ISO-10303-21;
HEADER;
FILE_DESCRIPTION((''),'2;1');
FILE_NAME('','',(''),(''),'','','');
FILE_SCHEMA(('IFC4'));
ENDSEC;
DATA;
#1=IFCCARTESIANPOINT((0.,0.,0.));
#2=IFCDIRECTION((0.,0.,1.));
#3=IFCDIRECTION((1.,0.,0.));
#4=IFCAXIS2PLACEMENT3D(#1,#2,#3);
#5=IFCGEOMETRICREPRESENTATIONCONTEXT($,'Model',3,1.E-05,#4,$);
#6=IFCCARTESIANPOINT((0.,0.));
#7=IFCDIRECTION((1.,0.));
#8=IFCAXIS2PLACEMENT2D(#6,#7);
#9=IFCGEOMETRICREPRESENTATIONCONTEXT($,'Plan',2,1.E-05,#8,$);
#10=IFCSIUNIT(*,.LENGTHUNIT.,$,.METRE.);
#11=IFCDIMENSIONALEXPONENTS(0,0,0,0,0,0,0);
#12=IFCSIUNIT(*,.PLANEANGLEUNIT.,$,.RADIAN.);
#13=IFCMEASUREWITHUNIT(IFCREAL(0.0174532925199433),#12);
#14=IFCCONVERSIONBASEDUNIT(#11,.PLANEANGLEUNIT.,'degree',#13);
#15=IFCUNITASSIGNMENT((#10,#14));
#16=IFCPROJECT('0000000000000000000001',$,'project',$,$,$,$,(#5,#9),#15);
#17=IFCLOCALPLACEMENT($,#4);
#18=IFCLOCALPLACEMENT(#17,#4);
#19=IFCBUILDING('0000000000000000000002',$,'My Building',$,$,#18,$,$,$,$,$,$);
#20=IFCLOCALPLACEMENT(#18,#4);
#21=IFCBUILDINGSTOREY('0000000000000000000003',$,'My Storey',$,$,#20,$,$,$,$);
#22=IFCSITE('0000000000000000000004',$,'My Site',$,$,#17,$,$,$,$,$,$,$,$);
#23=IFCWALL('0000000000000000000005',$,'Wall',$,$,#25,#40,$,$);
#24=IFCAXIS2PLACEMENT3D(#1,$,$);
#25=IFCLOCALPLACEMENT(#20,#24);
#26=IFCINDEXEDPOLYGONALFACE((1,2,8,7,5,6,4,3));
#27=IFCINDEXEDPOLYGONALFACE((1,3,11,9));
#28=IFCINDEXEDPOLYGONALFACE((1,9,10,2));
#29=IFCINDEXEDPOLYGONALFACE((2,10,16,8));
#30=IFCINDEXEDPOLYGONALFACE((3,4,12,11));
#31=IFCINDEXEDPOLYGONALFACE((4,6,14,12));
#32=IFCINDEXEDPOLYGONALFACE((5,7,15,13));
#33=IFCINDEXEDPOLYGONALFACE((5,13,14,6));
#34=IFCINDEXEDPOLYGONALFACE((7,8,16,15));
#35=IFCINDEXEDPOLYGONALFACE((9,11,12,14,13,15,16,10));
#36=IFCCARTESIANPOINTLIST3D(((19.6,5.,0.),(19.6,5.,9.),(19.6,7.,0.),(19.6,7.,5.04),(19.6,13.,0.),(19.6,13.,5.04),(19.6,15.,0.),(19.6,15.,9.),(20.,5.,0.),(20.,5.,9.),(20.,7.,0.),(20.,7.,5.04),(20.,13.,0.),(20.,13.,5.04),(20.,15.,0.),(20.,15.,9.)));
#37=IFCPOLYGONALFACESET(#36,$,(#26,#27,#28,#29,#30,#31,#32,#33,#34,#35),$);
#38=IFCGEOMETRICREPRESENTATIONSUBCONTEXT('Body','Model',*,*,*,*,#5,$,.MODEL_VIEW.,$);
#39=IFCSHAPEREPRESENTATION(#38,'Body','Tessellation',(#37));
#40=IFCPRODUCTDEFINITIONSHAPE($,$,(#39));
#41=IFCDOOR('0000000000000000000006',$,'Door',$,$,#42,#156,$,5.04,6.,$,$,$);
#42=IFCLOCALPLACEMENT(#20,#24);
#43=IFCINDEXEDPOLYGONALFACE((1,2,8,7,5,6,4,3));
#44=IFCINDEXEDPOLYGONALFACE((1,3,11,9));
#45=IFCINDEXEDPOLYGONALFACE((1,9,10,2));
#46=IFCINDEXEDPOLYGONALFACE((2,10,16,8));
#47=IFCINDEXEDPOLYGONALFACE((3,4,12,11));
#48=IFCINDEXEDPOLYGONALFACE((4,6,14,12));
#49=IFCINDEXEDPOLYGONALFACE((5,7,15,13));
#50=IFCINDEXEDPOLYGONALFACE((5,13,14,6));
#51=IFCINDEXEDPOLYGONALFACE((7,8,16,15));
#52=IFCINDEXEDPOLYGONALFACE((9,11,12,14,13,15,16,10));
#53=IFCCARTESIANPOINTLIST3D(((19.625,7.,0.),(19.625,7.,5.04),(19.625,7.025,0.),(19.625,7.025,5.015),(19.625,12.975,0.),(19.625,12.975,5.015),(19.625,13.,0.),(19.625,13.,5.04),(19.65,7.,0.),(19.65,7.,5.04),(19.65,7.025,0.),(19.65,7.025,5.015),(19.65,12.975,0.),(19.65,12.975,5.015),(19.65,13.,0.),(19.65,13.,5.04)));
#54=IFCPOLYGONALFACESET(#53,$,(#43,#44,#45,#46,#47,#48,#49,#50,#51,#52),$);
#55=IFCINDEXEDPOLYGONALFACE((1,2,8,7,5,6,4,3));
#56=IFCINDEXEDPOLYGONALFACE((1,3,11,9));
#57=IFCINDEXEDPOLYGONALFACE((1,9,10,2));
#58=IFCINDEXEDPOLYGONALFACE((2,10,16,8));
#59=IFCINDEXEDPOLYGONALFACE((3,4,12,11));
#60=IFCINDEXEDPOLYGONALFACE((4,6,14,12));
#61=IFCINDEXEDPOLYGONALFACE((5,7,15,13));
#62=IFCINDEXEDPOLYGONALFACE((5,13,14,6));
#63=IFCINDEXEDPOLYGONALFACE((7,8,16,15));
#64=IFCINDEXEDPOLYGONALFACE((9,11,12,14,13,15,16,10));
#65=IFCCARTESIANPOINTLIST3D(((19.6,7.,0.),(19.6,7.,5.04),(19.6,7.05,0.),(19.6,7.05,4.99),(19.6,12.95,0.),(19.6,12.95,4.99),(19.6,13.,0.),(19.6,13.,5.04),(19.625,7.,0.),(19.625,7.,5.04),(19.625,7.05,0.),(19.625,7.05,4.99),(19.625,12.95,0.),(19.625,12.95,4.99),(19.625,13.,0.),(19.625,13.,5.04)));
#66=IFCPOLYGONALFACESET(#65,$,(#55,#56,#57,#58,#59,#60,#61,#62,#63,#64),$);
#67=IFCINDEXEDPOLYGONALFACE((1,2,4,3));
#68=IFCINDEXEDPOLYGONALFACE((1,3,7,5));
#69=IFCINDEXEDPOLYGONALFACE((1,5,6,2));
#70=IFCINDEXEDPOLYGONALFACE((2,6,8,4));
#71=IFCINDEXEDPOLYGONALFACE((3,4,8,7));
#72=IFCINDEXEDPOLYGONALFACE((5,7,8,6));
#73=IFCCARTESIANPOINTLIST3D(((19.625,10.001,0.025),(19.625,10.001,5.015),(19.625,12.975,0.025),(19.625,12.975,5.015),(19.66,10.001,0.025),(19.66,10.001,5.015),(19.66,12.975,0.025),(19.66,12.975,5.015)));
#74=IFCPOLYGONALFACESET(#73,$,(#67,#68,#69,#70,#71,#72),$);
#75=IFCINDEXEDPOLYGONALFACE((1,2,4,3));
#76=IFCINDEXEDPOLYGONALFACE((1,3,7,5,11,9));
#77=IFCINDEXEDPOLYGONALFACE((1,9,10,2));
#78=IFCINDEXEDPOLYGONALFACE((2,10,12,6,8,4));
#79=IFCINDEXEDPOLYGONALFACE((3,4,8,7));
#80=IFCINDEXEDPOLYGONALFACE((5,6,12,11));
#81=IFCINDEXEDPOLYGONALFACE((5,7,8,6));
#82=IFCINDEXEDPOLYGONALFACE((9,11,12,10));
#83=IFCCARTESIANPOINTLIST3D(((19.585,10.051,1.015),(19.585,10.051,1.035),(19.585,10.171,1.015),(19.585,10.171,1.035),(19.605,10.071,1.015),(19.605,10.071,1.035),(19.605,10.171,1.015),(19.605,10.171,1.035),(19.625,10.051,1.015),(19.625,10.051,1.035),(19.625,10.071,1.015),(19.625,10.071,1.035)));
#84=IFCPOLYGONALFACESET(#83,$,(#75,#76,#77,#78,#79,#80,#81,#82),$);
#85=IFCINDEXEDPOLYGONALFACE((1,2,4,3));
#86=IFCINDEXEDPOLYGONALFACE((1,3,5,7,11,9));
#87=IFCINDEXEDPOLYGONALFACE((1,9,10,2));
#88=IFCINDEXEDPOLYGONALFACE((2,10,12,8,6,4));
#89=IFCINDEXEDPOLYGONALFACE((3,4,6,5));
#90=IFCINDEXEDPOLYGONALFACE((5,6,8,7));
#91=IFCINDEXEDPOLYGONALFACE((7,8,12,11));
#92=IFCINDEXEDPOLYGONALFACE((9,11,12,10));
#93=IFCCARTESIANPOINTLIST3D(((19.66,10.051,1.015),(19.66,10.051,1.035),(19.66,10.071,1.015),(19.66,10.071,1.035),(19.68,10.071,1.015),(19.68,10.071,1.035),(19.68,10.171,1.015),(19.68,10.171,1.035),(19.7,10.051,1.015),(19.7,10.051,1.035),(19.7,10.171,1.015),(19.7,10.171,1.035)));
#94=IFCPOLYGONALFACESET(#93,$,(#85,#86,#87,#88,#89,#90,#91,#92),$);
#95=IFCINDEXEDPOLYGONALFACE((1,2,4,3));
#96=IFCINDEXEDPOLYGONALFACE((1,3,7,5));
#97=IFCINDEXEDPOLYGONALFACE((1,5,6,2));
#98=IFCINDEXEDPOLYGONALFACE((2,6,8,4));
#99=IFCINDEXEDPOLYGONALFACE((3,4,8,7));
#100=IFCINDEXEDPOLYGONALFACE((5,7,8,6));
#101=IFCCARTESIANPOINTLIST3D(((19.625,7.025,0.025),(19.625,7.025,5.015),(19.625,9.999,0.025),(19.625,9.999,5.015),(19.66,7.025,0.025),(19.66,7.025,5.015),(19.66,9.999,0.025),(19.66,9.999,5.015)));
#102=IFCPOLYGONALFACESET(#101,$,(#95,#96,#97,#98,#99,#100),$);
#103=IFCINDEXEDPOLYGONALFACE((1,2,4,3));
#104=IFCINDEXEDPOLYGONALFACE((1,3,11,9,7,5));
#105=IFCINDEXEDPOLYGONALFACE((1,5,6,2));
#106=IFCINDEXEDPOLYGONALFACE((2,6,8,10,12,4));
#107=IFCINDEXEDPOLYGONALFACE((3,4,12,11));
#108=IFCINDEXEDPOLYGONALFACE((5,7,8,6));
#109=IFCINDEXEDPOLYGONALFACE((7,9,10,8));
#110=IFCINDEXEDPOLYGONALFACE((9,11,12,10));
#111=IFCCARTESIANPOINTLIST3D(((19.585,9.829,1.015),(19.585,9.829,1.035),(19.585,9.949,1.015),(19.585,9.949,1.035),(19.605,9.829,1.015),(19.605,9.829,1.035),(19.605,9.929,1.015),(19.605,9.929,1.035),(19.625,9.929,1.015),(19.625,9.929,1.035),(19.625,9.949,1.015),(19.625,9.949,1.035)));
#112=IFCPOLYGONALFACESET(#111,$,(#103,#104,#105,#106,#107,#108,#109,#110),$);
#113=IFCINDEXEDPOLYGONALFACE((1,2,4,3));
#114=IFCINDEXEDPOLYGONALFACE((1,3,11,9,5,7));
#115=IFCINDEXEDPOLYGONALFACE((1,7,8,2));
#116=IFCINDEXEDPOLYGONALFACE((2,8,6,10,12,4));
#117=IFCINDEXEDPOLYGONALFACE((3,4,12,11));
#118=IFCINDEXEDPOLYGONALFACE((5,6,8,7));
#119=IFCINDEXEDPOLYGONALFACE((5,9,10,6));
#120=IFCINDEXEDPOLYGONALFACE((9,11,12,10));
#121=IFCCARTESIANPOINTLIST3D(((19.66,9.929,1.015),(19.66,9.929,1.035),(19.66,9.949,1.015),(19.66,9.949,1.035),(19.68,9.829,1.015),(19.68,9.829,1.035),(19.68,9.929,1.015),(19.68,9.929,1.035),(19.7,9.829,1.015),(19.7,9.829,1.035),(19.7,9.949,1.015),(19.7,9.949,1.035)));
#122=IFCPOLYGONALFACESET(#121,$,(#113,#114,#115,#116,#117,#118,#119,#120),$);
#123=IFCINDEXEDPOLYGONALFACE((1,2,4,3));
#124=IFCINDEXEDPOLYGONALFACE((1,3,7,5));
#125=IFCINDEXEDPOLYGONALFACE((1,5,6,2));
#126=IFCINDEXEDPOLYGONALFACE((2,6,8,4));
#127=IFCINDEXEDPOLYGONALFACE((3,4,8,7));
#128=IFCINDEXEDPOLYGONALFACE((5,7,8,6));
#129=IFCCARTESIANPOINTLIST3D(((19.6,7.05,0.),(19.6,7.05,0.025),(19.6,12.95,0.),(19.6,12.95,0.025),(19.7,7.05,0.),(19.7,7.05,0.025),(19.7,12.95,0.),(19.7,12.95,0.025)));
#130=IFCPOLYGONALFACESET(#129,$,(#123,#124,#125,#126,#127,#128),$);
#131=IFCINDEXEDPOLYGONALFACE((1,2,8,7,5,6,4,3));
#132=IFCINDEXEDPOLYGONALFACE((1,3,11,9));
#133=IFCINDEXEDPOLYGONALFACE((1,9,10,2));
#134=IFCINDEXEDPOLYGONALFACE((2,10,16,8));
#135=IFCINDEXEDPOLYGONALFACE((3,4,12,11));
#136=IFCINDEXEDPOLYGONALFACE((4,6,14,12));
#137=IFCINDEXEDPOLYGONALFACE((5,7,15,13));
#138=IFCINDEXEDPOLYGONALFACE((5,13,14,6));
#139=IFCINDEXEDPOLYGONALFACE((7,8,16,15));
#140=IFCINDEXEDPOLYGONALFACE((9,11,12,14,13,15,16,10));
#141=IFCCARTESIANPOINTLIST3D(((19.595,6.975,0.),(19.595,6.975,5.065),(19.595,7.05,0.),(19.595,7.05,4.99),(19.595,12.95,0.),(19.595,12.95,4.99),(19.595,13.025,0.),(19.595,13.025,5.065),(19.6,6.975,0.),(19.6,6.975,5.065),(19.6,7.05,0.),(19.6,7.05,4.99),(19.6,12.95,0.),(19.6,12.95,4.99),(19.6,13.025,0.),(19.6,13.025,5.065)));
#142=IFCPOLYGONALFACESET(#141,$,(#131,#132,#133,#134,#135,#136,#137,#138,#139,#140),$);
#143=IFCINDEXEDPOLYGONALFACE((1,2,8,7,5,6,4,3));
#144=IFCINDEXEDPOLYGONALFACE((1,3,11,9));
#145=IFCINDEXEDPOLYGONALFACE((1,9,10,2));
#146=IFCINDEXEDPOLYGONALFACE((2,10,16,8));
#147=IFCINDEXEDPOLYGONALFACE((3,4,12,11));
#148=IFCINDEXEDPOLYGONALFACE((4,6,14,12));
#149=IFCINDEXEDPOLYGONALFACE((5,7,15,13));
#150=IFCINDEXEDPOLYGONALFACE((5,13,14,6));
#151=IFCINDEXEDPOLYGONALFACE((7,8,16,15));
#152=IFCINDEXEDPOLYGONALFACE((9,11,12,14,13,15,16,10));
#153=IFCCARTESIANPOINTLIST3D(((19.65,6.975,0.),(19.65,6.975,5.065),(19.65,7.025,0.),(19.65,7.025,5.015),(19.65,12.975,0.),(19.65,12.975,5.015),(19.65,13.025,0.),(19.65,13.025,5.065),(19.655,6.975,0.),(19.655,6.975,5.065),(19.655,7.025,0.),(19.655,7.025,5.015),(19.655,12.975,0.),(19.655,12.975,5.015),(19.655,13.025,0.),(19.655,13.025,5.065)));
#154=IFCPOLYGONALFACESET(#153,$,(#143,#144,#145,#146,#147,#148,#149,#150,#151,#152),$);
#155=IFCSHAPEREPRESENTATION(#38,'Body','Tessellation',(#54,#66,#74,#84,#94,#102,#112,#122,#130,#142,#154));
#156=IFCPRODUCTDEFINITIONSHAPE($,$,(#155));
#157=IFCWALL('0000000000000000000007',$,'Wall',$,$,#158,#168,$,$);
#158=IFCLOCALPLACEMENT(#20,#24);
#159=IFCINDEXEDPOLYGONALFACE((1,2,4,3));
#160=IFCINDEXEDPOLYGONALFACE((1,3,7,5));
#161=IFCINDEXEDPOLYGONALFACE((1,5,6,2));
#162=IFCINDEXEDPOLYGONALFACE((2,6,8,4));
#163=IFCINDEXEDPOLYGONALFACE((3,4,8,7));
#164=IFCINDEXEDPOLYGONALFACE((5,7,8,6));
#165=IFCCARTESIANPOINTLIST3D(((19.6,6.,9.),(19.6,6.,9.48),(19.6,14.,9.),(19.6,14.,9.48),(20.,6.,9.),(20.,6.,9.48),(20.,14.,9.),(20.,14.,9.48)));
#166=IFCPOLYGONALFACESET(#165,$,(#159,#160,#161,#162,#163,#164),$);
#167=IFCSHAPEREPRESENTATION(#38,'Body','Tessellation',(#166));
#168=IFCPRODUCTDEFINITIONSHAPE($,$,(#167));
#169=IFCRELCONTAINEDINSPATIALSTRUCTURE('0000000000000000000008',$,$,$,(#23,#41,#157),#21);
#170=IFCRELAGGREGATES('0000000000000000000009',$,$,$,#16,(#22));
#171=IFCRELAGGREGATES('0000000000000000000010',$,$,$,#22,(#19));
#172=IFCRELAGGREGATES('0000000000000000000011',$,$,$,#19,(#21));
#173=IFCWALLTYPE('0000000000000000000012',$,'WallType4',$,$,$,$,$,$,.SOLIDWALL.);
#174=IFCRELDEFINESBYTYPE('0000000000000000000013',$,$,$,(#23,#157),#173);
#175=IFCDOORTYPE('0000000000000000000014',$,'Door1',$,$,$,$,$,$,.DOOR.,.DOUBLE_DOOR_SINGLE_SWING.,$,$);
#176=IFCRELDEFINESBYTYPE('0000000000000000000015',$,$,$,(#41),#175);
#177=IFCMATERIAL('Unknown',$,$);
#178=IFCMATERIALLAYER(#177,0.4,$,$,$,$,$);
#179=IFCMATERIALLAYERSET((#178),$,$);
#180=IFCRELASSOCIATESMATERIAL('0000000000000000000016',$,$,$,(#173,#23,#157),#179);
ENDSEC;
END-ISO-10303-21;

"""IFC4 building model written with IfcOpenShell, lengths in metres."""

from ifc_helpers import new_model, entity, si_unit, converted_unit, frame, origin_with_axes, origin_2d_with_axis, place, context, subcontext, project, spatial, line, indexed_curve, outline, extrude, shape, source, transform, mapped, material, layer, layer_set, layer_usage, type_object, type_shapes, element, fill, save


model = new_model("IFC4")

# Units and contexts
model_context = context("Model", 3, precision=1e-05, world=origin_with_axes())
plan_context = context("Plan", 2, precision=1e-05, world=origin_2d_with_axis())
body_context_1 = subcontext(model_context, "Body", "Model", "MODEL_VIEW")
body_context_2 = subcontext(plan_context, "Body", "Plan", "PLAN_VIEW")
ifc_project = project(units=[si_unit("LENGTHUNIT", "METRE"), converted_unit("PLANEANGLEUNIT", "degree", entity("IfcReal", 0.0174532925199433), si_unit("PLANEANGLEUNIT", "RADIAN"), dimensions=[0, 0, 0, 0, 0, 0, 0])], contexts=[model_context, plan_context])

# Site, building, storey
site_placement = place(None, origin_with_axes())
site = spatial("IfcSite", under=ifc_project, at=site_placement, Name="My Site")
building_placement = place(site_placement, origin_with_axes())
building = spatial("IfcBuilding", under=site, at=building_placement, Name="My Building")
storey_placement = place(building_placement, origin_with_axes())
storey = spatial("IfcBuildingStorey", under=building, at=storey_placement, Name="My Storey")

# Shared definitions
ifc_material = material(Name="Unknown")
ifc_layer = layer(ifc_material, 0.4)
ifc_layer_set = layer_set([ifc_layer])
wall_type = type_object("IfcWallType", Name="WallType4", PredefinedType="SOLIDWALL", material=ifc_layer_set)

# Wall, opening, door
shared_shape_1 = source(origin_with_axes(), body_context_1, "Body", "SweptSolid", [
    extrude(outline(indexed_curve([(0.0, 0.0), (6.0, 0.0), (6.0, 5.04), (0.0, 5.04)], segments=[line(1, 2, 3, 4, 1)])), frame((0.0, -0.1, 0.0), z_axis=(0.0, -1.0, 0.0), x_axis=(1.0, 0.0, 0.0)), (0.0, 0.0, -1.0), 0.6),
])
door_type_1 = type_object("IfcDoorType", Name="Door1", OperationType="DOUBLE_DOOR_SINGLE_SWING", PredefinedType="DOOR")
shared_shape_2 = source(origin_with_axes(), body_context_1, "Body", "SweptSolid", [
    extrude(outline(indexed_curve([(0.0, 0.0), (0.0, 5.04), (6.0, 5.04), (6.0, 0.0), (5.975, 0.0), (5.975, 5.015), (0.025, 5.015), (0.025, 0.0)], segments=[line(1, 2, 3, 4, 5, 6, 7, 8, 1)])), frame((0.0, 0.025, 0.0), z_axis=(0.0, -1.0, 0.0), x_axis=(1.0, 0.0, 0.0)), (0.0, 0.0, -1.0), 0.025),
    extrude(outline(indexed_curve([(0.0, 0.0), (0.0, 5.04), (6.0, 5.04), (6.0, 0.0), (5.95, 0.0), (5.95, 4.99), (0.05, 4.99), (0.05, 0.0)], segments=[line(1, 2, 3, 4, 5, 6, 7, 8, 1)])), frame((0.0, 0.0, 0.0), z_axis=(0.0, -1.0, 0.0), x_axis=(1.0, 0.0, 0.0)), (0.0, 0.0, -1.0), 0.025),
    extrude(outline(indexed_curve([(0.0, 0.0), (2.974, 0.0), (2.974, 0.035), (0.0, 0.035)], segments=[line(1, 2, 3, 4, 1)])), frame((0.025, 0.025, 0.025), z_axis=(0.0, 0.0, 1.0), x_axis=(1.0, 0.0, 0.0)), (0.0, 0.0, 1.0), 4.99),
    extrude(outline(indexed_curve([(0.0, 0.0), (0.0, -0.04), (-0.12, -0.04), (-0.12, -0.02), (-0.02, -0.02), (-0.02, 0.0)], segments=[line(1, 2, 3, 4, 5, 6, 1)])), frame((2.949, 0.025, 1.015), z_axis=(0.0, 0.0, 1.0), x_axis=(1.0, 0.0, 0.0)), (0.0, 0.0, 1.0), 0.02),
    extrude(outline(indexed_curve([(0.0, 0.0), (0.0, 0.04), (-0.12, 0.04), (-0.12, 0.02), (-0.02, 0.02), (-0.02, 0.0)], segments=[line(1, 2, 3, 4, 5, 6, 1)])), frame((2.949, 0.06, 1.015), z_axis=(0.0, 0.0, 1.0), x_axis=(1.0, 0.0, 0.0)), (0.0, 0.0, 1.0), 0.02),
    extrude(outline(indexed_curve([(0.0, 0.0), (-2.974, 0.0), (-2.974, 0.035), (0.0, 0.035)], segments=[line(1, 2, 3, 4, 1)])), frame((5.975, 0.025, 0.025), z_axis=(0.0, 0.0, 1.0), x_axis=(1.0, 0.0, 0.0)), (0.0, 0.0, 1.0), 4.99),
    extrude(outline(indexed_curve([(0.0, 0.0), (0.0, -0.04), (0.12, -0.04), (0.12, -0.02), (0.02, -0.02), (0.02, 0.0)], segments=[line(1, 2, 3, 4, 5, 6, 1)])), frame((3.051, 0.025, 1.015), z_axis=(0.0, 0.0, 1.0), x_axis=(1.0, 0.0, 0.0)), (0.0, 0.0, 1.0), 0.02),
    extrude(outline(indexed_curve([(0.0, 0.0), (0.0, 0.04), (0.12, 0.04), (0.12, 0.02), (0.02, 0.02), (0.02, 0.0)], segments=[line(1, 2, 3, 4, 5, 6, 1)])), frame((3.051, 0.06, 1.015), z_axis=(0.0, 0.0, 1.0), x_axis=(1.0, 0.0, 0.0)), (0.0, 0.0, 1.0), 0.02),
    extrude(outline(indexed_curve([(0.0, 0.0), (5.9, 0.0), (5.9, 0.1), (0.0, 0.1)], segments=[line(1, 2, 3, 4, 1)])), frame((0.05, 0.0, 0.0), z_axis=(0.0, 0.0, 1.0), x_axis=(1.0, 0.0, 0.0)), (0.0, 0.0, 1.0), 0.025),
    extrude(outline(indexed_curve([(0.0, 0.0), (0.0, 5.065), (6.05, 5.065), (6.05, 0.0), (5.975, 0.0), (5.975, 4.99), (0.075, 4.99), (0.075, 0.0)], segments=[line(1, 2, 3, 4, 5, 6, 7, 8, 1)])), frame((-0.025, -0.005, 0.0), z_axis=(0.0, -1.0, 0.0), x_axis=(1.0, 0.0, 0.0)), (0.0, 0.0, -1.0), 0.005),
    extrude(outline(indexed_curve([(0.0, 0.0), (0.0, 5.065), (6.05, 5.065), (6.05, 0.0), (6.0, 0.0), (6.0, 5.015), (0.05, 5.015), (0.05, 0.0)], segments=[line(1, 2, 3, 4, 5, 6, 7, 8, 1)])), frame((-0.025, 0.05, 0.0), z_axis=(0.0, -1.0, 0.0), x_axis=(1.0, 0.0, 0.0)), (0.0, 0.0, -1.0), 0.005),
])
shared_shape_3 = source(origin_with_axes(), body_context_2, "Body", "Curve2D", [
    entity("IfcIndexedPolyCurve", entity("IfcCartesianPointList2D", [[0.0, 0.0], [0.0, 0.05], [0.025, 0.05], [0.025, 0.025], [0.05, 0.025], [0.05, 0.0]]), [entity("IfcLineIndex", [1, 2, 3, 4, 5, 6, 1])]),
    entity("IfcIndexedPolyCurve", entity("IfcCartesianPointList2D", [[6.0, 0.0], [6.0, 0.05], [5.975, 0.05], [5.975, 0.025], [5.95, 0.025], [5.95, 0.0]]), [entity("IfcLineIndex", [1, 2, 3, 4, 5, 6, 1])]),
    entity("IfcTrimmedCurve", entity("IfcEllipse", entity("IfcAxis2Placement2D", entity("IfcCartesianPoint", [0.06, 0.05]), entity("IfcDirection", [1.0, 0.0])), 2.94, 2.975), [entity("IfcCartesianPoint", [3.0, 0.05])], [entity("IfcCartesianPoint", [0.06, 3.025])], True, "CARTESIAN"),
    entity("IfcIndexedPolyCurve", entity("IfcCartesianPointList2D", [[0.025, 0.05], [0.06, 0.05], [0.06, 3.025], [0.025, 3.025]]), [entity("IfcLineIndex", [1, 2, 3, 4, 1])]),
    entity("IfcTrimmedCurve", entity("IfcEllipse", entity("IfcAxis2Placement2D", entity("IfcCartesianPoint", [5.94, 0.05]), entity("IfcDirection", [1.0, 0.0])), 2.94, 2.975), [entity("IfcCartesianPoint", [5.94, 3.025])], [entity("IfcCartesianPoint", [3.0, 0.05])], True, "CARTESIAN"),
    entity("IfcIndexedPolyCurve", entity("IfcCartesianPointList2D", [[5.975, 0.05], [5.94, 0.05], [5.94, 3.025], [5.975, 3.025]]), [entity("IfcLineIndex", [1, 2, 3, 4, 1])]),
])
type_shapes(door_type_1, [shared_shape_2, shared_shape_3])
ifc_layer_usage_1 = layer_usage(ifc_layer_set, "AXIS2", "POSITIVE", 0.0)
wall_1_placement = place(storey_placement, frame((19.6, 15.0, 0.0), z_axis=(0.0, 0.0, 1.0), x_axis=(0.0, -1.0, 0.0)))
wall_1 = element("IfcWall", 1, at=wall_1_placement, inside=storey, type_object=wall_type, material=ifc_layer_usage_1, Name="Wall", context=body_context_1, shape_type="SweptSolid", body=[
    extrude(outline(indexed_curve([(0.0, 0.0), (0.0, 0.4), (10.0, 0.4), (10.0, 0.0), (0.0, 0.0)], self_intersect=False)), origin_with_axes(), (0.0, 0.0, 1.0), 9.0),
])
opening_1_placement = place(wall_1_placement, frame((2.0, 0.0, 0.0), z_axis=(0.0, 0.0, 1.0), x_axis=(1.0, 0.0, 0.0)))
opening_1 = element("IfcOpeningElement", 2, at=opening_1_placement, cuts=wall_1, PredefinedType="OPENING", context=body_context_1, shape_type="MappedRepresentation", body=[
    mapped(shared_shape_1, transform((0.0, 0.0, 0.0), x_axis=(1.0, 0.0, 0.0), y_axis=(0.0, 1.0, 0.0), z_axis=(0.0, 0.0, 1.0), scale=1.0)),
])
door_1_placement = place(opening_1_placement, frame((0.0, 0.0, 0.0), z_axis=(0.0, 0.0, 1.0), x_axis=(1.0, 0.0, 0.0)))
door_1 = element("IfcDoor", 3, at=door_1_placement, inside=storey, type_object=door_type_1, Name="Door", OverallHeight=5.04, OverallWidth=6.0, shapes=[
    shape(body_context_1, "Body", "MappedRepresentation", [mapped(shared_shape_2, transform((0.0, 0.0, 0.0), x_axis=(1.0, 0.0, 0.0), y_axis=(0.0, 1.0, 0.0), z_axis=(0.0, 0.0, 1.0), scale=1.0))]),
    shape(body_context_2, "Body", "MappedRepresentation", [mapped(shared_shape_3, transform((0.0, 0.0, 0.0), x_axis=(1.0, 0.0, 0.0), y_axis=(0.0, 1.0, 0.0), z_axis=(0.0, 0.0, 1.0), scale=1.0))]),
])
fill(opening_1, door_1)

# Wall
ifc_layer_usage_2 = layer_usage(ifc_layer_set, "AXIS2", "POSITIVE", 0.0)
wall_2_placement = place(storey_placement, frame((20.0, 6.0, 9.0), z_axis=(0.0, 0.0, 1.0), x_axis=(0.0, 1.0, 0.0)))
element("IfcWall", 4, at=wall_2_placement, inside=storey, type_object=wall_type, material=ifc_layer_usage_2, Name="Wall", context=body_context_1, shape_type="SweptSolid", body=[
    extrude(outline(indexed_curve([(0.0, 0.0), (0.0, 0.4), (8.0, 0.4), (8.0, 0.0), (0.0, 0.0)], self_intersect=False)), origin_with_axes(), (0.0, 0.0, 1.0), 0.48),
])

save(model, "model.ifc")
